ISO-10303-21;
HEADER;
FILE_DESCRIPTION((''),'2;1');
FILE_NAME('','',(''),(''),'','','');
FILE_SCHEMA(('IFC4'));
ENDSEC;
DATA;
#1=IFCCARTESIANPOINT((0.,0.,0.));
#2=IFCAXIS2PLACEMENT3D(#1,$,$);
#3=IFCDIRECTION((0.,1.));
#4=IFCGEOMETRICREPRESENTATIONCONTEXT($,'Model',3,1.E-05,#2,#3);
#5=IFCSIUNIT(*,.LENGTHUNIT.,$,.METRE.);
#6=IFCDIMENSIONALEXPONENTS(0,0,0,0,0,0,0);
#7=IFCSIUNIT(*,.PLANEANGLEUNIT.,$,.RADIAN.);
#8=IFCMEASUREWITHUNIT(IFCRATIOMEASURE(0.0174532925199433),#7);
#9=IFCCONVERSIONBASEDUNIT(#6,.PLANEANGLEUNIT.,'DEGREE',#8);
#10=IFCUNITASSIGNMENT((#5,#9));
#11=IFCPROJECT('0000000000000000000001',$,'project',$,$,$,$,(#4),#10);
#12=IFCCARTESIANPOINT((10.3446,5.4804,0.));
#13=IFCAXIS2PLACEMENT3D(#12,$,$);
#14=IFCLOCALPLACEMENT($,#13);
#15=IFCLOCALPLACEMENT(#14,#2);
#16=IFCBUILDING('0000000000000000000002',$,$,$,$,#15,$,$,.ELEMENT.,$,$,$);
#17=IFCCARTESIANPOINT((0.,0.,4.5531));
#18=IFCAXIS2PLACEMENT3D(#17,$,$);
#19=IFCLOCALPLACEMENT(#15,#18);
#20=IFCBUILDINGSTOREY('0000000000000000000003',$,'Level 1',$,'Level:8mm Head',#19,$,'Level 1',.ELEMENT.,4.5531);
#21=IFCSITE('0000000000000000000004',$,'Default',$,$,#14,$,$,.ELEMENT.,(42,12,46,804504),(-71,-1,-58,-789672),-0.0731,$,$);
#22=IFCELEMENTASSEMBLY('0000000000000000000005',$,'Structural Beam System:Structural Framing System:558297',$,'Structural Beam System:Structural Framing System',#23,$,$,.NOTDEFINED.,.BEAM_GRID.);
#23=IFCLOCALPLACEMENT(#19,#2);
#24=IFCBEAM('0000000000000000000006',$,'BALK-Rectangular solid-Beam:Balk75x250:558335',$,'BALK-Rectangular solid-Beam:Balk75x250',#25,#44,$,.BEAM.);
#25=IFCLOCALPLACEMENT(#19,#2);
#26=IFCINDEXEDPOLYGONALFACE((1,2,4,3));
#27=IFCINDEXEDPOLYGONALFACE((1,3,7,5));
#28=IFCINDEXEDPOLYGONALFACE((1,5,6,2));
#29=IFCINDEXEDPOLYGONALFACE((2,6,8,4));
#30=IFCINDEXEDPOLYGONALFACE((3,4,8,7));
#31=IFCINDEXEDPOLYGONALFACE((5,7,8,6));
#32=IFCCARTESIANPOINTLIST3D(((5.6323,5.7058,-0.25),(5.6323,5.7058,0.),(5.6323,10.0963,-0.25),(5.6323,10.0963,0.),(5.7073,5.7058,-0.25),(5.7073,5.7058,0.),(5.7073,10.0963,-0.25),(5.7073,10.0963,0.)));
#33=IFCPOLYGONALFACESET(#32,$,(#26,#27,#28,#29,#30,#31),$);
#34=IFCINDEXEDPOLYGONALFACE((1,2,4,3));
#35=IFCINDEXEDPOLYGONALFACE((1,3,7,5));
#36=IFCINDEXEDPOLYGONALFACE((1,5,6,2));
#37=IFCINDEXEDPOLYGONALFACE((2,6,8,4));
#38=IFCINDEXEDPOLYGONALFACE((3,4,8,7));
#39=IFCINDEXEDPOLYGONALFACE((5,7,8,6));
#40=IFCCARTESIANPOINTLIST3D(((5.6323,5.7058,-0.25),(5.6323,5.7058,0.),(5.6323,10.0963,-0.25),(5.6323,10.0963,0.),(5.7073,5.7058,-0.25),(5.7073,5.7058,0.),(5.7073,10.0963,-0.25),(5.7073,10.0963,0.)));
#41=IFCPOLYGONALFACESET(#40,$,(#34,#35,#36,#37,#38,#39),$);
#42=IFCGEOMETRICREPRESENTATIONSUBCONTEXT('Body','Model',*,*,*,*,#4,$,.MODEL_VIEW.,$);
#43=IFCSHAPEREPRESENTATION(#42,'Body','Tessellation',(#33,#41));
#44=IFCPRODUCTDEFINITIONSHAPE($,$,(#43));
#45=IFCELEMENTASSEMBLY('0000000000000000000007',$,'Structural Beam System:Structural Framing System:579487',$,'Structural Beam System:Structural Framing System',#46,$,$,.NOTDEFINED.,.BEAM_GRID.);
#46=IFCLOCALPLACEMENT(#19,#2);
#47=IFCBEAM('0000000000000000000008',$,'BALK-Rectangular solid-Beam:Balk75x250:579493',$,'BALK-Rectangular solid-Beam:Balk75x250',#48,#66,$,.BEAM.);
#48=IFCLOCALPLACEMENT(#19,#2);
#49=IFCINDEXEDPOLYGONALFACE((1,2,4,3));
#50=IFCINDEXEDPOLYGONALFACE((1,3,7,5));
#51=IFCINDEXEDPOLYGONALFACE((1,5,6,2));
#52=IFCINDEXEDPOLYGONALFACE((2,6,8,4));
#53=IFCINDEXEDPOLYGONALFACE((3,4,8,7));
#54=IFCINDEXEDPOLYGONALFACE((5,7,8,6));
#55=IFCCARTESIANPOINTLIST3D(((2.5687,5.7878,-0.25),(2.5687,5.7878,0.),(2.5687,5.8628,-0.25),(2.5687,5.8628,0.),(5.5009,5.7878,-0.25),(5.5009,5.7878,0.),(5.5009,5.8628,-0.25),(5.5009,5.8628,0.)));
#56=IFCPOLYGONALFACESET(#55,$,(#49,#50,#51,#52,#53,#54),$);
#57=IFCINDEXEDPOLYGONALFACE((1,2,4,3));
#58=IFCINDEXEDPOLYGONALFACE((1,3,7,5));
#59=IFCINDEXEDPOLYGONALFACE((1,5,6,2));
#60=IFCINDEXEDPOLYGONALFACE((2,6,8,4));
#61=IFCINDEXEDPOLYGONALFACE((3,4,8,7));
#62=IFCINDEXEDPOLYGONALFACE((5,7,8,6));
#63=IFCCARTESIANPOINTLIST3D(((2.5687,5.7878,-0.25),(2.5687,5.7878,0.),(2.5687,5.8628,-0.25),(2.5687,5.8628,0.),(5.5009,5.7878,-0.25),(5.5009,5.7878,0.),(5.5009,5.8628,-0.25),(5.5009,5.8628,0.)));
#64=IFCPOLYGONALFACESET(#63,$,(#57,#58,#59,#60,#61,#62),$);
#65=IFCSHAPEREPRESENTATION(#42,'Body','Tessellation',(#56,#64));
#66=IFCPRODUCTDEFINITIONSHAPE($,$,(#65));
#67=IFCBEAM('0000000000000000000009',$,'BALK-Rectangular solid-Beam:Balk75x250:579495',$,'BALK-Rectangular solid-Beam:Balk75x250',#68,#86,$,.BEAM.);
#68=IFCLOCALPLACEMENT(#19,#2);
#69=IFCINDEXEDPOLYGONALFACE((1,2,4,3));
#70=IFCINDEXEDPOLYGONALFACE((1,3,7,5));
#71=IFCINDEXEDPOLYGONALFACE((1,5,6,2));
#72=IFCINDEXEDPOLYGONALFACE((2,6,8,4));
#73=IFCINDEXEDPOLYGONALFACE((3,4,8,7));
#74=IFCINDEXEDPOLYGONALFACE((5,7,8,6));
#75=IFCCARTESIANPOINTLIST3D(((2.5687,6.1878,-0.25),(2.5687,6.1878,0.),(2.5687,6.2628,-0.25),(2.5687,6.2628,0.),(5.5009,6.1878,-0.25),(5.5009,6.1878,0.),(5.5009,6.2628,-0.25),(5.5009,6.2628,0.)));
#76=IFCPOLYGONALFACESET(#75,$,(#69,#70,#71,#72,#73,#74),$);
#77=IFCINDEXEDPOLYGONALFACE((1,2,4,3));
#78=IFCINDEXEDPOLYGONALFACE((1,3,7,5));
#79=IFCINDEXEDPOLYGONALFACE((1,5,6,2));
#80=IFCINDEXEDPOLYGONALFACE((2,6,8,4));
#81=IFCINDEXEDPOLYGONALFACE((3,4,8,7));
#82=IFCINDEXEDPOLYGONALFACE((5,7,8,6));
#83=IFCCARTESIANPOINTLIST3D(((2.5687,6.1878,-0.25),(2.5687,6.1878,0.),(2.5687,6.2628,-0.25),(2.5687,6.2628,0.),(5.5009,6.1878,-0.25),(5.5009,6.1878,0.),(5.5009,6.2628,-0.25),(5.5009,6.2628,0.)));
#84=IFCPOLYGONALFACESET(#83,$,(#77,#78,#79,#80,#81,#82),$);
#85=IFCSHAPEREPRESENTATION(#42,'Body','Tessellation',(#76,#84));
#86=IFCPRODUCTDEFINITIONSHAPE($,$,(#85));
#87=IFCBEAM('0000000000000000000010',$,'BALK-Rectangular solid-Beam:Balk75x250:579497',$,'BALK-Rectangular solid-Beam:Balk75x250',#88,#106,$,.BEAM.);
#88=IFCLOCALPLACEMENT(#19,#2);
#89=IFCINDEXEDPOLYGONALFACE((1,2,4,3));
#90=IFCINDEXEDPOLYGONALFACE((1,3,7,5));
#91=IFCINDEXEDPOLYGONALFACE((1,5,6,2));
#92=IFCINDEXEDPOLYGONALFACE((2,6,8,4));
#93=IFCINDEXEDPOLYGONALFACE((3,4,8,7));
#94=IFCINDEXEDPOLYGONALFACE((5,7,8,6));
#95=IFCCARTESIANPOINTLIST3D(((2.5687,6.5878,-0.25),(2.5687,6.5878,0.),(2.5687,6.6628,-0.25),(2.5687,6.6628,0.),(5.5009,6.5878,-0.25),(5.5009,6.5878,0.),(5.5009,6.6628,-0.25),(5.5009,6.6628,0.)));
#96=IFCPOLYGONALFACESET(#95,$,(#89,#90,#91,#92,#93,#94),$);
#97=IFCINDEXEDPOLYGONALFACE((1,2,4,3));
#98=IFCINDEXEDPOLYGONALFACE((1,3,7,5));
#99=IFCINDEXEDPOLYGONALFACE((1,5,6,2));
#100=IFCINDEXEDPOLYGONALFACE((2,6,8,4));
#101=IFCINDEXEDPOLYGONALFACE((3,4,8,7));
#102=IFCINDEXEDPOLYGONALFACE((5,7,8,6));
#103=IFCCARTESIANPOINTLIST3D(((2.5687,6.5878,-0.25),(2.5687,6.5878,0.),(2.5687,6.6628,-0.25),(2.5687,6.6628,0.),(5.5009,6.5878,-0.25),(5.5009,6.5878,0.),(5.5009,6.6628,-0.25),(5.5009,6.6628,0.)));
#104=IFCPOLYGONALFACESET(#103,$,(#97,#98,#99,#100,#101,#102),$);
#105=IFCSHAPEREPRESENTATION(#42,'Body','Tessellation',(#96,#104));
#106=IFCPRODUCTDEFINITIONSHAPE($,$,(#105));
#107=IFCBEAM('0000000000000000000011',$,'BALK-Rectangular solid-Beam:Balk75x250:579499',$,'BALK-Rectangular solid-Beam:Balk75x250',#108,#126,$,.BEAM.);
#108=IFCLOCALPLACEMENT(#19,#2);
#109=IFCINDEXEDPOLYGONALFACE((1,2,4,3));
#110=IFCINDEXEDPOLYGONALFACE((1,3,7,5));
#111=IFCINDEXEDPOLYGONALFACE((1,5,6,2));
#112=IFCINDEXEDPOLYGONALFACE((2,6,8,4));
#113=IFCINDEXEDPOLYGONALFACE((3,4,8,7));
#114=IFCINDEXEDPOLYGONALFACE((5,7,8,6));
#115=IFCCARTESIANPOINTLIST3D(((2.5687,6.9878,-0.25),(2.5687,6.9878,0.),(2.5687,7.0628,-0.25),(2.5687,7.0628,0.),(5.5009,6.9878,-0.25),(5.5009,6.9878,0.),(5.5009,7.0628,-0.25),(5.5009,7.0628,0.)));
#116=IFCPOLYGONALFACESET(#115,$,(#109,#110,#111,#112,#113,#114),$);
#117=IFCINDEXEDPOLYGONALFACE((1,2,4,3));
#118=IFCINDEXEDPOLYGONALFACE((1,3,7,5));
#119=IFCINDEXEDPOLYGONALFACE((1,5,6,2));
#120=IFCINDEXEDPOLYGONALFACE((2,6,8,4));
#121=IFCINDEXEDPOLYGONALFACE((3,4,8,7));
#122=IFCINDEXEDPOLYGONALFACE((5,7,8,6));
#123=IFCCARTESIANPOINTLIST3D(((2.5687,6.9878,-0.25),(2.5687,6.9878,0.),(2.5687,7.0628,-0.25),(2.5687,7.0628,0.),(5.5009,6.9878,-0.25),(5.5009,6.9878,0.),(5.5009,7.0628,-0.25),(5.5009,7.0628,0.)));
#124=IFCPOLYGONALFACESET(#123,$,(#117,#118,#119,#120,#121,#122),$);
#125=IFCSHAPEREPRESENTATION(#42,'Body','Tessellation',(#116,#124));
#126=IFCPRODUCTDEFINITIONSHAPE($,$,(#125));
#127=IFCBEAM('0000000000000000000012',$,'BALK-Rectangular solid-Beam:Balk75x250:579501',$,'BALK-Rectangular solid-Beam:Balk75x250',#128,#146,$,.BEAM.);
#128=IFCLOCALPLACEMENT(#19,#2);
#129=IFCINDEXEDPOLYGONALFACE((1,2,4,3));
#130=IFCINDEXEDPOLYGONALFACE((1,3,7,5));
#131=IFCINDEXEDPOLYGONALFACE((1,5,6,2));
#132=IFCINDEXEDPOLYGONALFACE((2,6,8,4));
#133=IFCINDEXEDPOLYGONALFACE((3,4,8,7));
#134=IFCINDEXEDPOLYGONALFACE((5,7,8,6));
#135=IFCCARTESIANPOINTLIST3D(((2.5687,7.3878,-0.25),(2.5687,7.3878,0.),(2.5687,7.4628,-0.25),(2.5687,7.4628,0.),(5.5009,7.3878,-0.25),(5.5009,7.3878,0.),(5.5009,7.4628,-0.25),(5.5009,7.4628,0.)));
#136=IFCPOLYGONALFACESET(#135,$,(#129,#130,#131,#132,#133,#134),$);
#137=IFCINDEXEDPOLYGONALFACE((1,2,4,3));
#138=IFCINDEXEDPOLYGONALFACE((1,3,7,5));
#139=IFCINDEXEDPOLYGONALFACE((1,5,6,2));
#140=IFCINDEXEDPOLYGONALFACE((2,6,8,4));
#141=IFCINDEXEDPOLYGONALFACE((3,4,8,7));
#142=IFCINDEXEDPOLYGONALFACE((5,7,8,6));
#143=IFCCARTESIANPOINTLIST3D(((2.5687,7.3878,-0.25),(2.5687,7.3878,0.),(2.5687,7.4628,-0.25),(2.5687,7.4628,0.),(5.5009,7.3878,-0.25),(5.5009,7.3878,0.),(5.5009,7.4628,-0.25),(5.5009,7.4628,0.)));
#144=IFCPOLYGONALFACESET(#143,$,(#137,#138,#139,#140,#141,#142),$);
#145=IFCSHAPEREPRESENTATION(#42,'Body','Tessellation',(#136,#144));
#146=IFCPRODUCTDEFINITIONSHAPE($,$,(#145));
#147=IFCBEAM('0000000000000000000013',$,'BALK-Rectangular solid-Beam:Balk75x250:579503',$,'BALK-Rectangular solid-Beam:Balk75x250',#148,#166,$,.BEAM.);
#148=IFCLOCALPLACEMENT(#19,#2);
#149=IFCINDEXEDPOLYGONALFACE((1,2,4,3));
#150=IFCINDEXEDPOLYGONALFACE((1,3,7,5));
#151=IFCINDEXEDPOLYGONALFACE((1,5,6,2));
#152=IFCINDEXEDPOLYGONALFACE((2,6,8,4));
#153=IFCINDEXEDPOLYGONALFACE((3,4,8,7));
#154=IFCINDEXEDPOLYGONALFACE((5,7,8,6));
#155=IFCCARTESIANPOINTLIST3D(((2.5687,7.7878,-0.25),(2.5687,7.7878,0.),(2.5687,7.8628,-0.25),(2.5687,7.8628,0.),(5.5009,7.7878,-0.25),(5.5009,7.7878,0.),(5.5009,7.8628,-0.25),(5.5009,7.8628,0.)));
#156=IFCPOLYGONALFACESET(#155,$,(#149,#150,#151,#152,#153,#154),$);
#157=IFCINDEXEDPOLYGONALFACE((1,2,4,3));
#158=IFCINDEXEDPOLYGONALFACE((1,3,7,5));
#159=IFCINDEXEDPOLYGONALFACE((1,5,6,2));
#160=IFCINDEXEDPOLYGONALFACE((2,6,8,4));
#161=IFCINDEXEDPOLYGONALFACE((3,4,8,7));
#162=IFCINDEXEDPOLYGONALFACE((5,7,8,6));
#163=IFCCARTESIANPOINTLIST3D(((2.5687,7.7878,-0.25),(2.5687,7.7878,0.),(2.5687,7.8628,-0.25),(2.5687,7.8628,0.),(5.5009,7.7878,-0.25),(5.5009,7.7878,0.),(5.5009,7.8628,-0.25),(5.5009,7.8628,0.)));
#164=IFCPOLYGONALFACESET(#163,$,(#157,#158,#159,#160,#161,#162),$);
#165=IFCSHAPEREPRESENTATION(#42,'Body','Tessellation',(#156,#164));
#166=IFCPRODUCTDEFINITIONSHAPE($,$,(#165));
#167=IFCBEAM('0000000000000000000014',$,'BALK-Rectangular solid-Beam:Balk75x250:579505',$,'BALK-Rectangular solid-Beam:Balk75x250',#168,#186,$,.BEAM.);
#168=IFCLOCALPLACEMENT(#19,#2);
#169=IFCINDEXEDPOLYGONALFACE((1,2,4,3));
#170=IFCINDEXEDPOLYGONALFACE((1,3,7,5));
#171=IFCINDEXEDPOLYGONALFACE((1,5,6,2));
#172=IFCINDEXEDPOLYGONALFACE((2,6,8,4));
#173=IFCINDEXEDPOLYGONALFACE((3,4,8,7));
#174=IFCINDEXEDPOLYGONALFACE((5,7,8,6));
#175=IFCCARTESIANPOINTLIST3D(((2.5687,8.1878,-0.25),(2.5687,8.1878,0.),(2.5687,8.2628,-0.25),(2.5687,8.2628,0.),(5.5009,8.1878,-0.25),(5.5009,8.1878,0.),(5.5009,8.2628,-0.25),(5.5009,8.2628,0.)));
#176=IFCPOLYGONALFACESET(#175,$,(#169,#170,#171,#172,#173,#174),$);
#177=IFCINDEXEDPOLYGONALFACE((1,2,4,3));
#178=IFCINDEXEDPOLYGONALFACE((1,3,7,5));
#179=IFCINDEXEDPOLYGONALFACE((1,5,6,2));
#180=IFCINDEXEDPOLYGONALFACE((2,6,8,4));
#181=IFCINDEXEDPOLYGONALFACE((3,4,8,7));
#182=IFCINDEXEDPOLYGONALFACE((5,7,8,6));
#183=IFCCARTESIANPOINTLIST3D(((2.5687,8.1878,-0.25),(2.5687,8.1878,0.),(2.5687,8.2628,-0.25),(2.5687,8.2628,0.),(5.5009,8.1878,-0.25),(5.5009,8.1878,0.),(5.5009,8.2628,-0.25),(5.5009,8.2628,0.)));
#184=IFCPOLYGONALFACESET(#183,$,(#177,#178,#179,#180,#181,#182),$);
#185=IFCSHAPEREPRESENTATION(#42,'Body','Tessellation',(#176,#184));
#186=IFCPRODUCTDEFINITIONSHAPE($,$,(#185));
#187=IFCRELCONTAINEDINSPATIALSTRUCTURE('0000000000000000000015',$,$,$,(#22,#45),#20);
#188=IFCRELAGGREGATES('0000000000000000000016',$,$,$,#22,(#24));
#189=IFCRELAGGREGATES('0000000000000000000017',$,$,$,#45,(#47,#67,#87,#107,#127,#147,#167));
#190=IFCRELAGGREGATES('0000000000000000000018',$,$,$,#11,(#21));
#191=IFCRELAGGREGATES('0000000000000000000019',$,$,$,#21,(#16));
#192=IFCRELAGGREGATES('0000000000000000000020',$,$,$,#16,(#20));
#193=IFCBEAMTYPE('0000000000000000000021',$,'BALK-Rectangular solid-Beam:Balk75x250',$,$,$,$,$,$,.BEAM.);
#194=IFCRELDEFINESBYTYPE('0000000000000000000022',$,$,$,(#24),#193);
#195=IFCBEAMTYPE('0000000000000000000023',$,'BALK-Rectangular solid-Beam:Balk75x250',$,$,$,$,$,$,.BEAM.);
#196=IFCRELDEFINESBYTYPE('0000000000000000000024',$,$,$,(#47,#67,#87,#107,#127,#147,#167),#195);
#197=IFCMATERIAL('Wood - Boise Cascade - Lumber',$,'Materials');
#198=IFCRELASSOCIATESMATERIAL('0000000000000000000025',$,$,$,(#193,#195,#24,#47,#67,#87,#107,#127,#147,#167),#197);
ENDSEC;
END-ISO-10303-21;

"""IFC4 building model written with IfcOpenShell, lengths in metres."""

from ifc_helpers import new_model, entity, si_unit, converted_unit, direction, frame, frame_2d, origin, origin_2d_with_axis, place, context, subcontext, project, spatial, rectangle, extrude, source, transform, mapped, material, material_profile, profile_set, profile_usage, type_object, type_shapes, element, aggregate, save


model = new_model("IFC4")

# Units and contexts
model_context = context("Model", 3, precision=1e-05, world=origin(), true_north=direction((0.0, 1.0)))
body_context = subcontext(model_context, "Body", "Model", "MODEL_VIEW")
ifc_project = project(units=[si_unit("LENGTHUNIT", "METRE"), converted_unit("PLANEANGLEUNIT", "DEGREE", entity("IfcRatioMeasure", 0.0174532925199433), si_unit("PLANEANGLEUNIT", "RADIAN"), dimensions=[0, 0, 0, 0, 0, 0, 0])], contexts=[model_context])

# Site, building, storey
site_placement = place(None, frame((10.3446, 5.4804, 0.0)))
site = spatial("IfcSite", under=ifc_project, at=site_placement, Name="Default", CompositionType="ELEMENT", RefLatitude=(42, 12, 46, 804504), RefLongitude=(-71, -1, -58, -789672), RefElevation=-0.0731)
building_placement = place(site_placement, origin())
building = spatial("IfcBuilding", under=site, at=building_placement, CompositionType="ELEMENT")
storey_placement = place(building_placement, frame((0.0, 0.0, 4.5531)))
storey = spatial("IfcBuildingStorey", under=building, at=storey_placement, Name="Level 1", ObjectType="Level:8mm Head", LongName="Level 1", CompositionType="ELEMENT", Elevation=4.5531)

# Element assembly, beam
assembly_1_placement = place(storey_placement, origin())
assembly_1 = element("IfcElementAssembly", 1, at=assembly_1_placement, inside=storey, Name="Structural Beam System:Structural Framing System:558297", ObjectType="Structural Beam System:Structural Framing System", AssemblyPlace="NOTDEFINED", PredefinedType="BEAM_GRID")
ifc_material_1 = material(Name="Wood - Boise Cascade - Lumber", Category="Materials")
ifc_material_profile = material_profile(ifc_material_1, rectangle(XDim=0.25, YDim=0.075, at=frame_2d((0.0, 0.0), x_axis=(1.0, 0.0))), Name="Balk75x250")
ifc_profile_set = profile_set([ifc_material_profile], Name="Balk75x250")
ifc_profile_usage_1 = profile_usage(ifc_profile_set, cardinal=8)
beam_type_1 = type_object("IfcBeamType", Name="BALK-Rectangular solid-Beam:Balk75x250", PredefinedType="BEAM", material=ifc_profile_set)
shared_shape_1 = source(origin(), body_context, "Body", "SweptSolid", [
    extrude(rectangle(XDim=0.25, YDim=0.075, at=origin_2d_with_axis()), frame((-2.089, 0.0, 0.0), z_axis=(1.0, 0.0, 0.0), x_axis=(0.0, 0.0, -1.0)), (0.0, 0.0, 1.0), 4.3905),
    extrude(rectangle(XDim=0.25, YDim=0.075, at=origin_2d_with_axis()), frame((-2.089, 0.0, 0.0), z_axis=(1.0, 0.0, 0.0), x_axis=(0.0, 0.0, -1.0)), (0.0, 0.0, 1.0), 4.3905),
])
type_shapes(beam_type_1, [shared_shape_1])
beam_1_placement = place(assembly_1_placement, frame((5.6698, 8.0073, -0.125), z_axis=(0.0, 0.0, 1.0), x_axis=(0.0, -1.0, 0.0)))
beam_1 = element("IfcBeam", 2, at=beam_1_placement, type_object=beam_type_1, material=ifc_profile_usage_1, Name="BALK-Rectangular solid-Beam:Balk75x250:558335", ObjectType="BALK-Rectangular solid-Beam:Balk75x250", PredefinedType="BEAM", context=body_context, shape_type="MappedRepresentation", body=[
    mapped(shared_shape_1, transform((0.0, 0.0, 0.0), scale=1.0)),
])
aggregate(assembly_1, [beam_1])

# Element assembly, beams
assembly_2_placement = place(storey_placement, origin())
assembly_2 = element("IfcElementAssembly", 3, at=assembly_2_placement, inside=storey, Name="Structural Beam System:Structural Framing System:579487", ObjectType="Structural Beam System:Structural Framing System", AssemblyPlace="NOTDEFINED", PredefinedType="BEAM_GRID")
ifc_profile_usage_2 = profile_usage(ifc_profile_set, cardinal=8)
beam_type_2 = type_object("IfcBeamType", Name="BALK-Rectangular solid-Beam:Balk75x250", PredefinedType="BEAM", material=ifc_profile_set)
shared_shape_2 = source(origin(), body_context, "Body", "SweptSolid", [
    extrude(rectangle(XDim=0.25, YDim=0.075, at=origin_2d_with_axis()), frame((-1.5724, 0.0, 0.0), z_axis=(1.0, 0.0, 0.0), x_axis=(0.0, 0.0, -1.0)), (0.0, 0.0, 1.0), 2.9322),
    extrude(rectangle(XDim=0.25, YDim=0.075, at=origin_2d_with_axis()), frame((-1.5724, 0.0, 0.0), z_axis=(1.0, 0.0, 0.0), x_axis=(0.0, 0.0, -1.0)), (0.0, 0.0, 1.0), 2.9322),
])
type_shapes(beam_type_2, [shared_shape_2])
beam_2_placement = place(assembly_2_placement, frame((3.9285, 5.8253, -0.125), z_axis=(0.0, 0.0, 1.0), x_axis=(-1.0, 0.0, 0.0)))
beam_2 = element("IfcBeam", 4, at=beam_2_placement, type_object=beam_type_2, material=ifc_profile_usage_2, Name="BALK-Rectangular solid-Beam:Balk75x250:579493", ObjectType="BALK-Rectangular solid-Beam:Balk75x250", PredefinedType="BEAM", context=body_context, shape_type="MappedRepresentation", body=[
    mapped(shared_shape_2, transform((0.0, 0.0, 0.0), scale=1.0)),
])
ifc_profile_usage_3 = profile_usage(ifc_profile_set, cardinal=8)
beam_3_placement = place(assembly_2_placement, frame((3.9285, 6.2253, -0.125), z_axis=(0.0, 0.0, 1.0), x_axis=(-1.0, 0.0, 0.0)))
beam_3 = element("IfcBeam", 5, at=beam_3_placement, type_object=beam_type_2, material=ifc_profile_usage_3, Name="BALK-Rectangular solid-Beam:Balk75x250:579495", ObjectType="BALK-Rectangular solid-Beam:Balk75x250", PredefinedType="BEAM", context=body_context, shape_type="MappedRepresentation", body=[
    mapped(shared_shape_2, transform((0.0, 0.0, 0.0), scale=1.0)),
])
ifc_profile_usage_4 = profile_usage(ifc_profile_set, cardinal=8)
beam_4_placement = place(assembly_2_placement, frame((3.9285, 6.6253, -0.125), z_axis=(0.0, 0.0, 1.0), x_axis=(-1.0, 0.0, 0.0)))
beam_4 = element("IfcBeam", 6, at=beam_4_placement, type_object=beam_type_2, material=ifc_profile_usage_4, Name="BALK-Rectangular solid-Beam:Balk75x250:579497", ObjectType="BALK-Rectangular solid-Beam:Balk75x250", PredefinedType="BEAM", context=body_context, shape_type="MappedRepresentation", body=[
    mapped(shared_shape_2, transform((0.0, 0.0, 0.0), scale=1.0)),
])
ifc_profile_usage_5 = profile_usage(ifc_profile_set, cardinal=8)
beam_5_placement = place(assembly_2_placement, frame((3.9285, 7.0253, -0.125), z_axis=(0.0, 0.0, 1.0), x_axis=(-1.0, 0.0, 0.0)))
beam_5 = element("IfcBeam", 7, at=beam_5_placement, type_object=beam_type_2, material=ifc_profile_usage_5, Name="BALK-Rectangular solid-Beam:Balk75x250:579499", ObjectType="BALK-Rectangular solid-Beam:Balk75x250", PredefinedType="BEAM", context=body_context, shape_type="MappedRepresentation", body=[
    mapped(shared_shape_2, transform((0.0, 0.0, 0.0), scale=1.0)),
])
ifc_profile_usage_6 = profile_usage(ifc_profile_set, cardinal=8)
beam_6_placement = place(assembly_2_placement, frame((3.9285, 7.4253, -0.125), z_axis=(0.0, 0.0, 1.0), x_axis=(-1.0, 0.0, 0.0)))
beam_6 = element("IfcBeam", 8, at=beam_6_placement, type_object=beam_type_2, material=ifc_profile_usage_6, Name="BALK-Rectangular solid-Beam:Balk75x250:579501", ObjectType="BALK-Rectangular solid-Beam:Balk75x250", PredefinedType="BEAM", context=body_context, shape_type="MappedRepresentation", body=[
    mapped(shared_shape_2, transform((0.0, 0.0, 0.0), scale=1.0)),
])
ifc_profile_usage_7 = profile_usage(ifc_profile_set, cardinal=8)
beam_7_placement = place(assembly_2_placement, frame((3.9285, 7.8253, -0.125), z_axis=(0.0, 0.0, 1.0), x_axis=(-1.0, 0.0, 0.0)))
beam_7 = element("IfcBeam", 9, at=beam_7_placement, type_object=beam_type_2, material=ifc_profile_usage_7, Name="BALK-Rectangular solid-Beam:Balk75x250:579503", ObjectType="BALK-Rectangular solid-Beam:Balk75x250", PredefinedType="BEAM", context=body_context, shape_type="MappedRepresentation", body=[
    mapped(shared_shape_2, transform((0.0, 0.0, 0.0), scale=1.0)),
])
ifc_profile_usage_8 = profile_usage(ifc_profile_set, cardinal=8)
beam_8_placement = place(assembly_2_placement, frame((3.9285, 8.2253, -0.125), z_axis=(0.0, 0.0, 1.0), x_axis=(-1.0, 0.0, 0.0)))
beam_8 = element("IfcBeam", 10, at=beam_8_placement, type_object=beam_type_2, material=ifc_profile_usage_8, Name="BALK-Rectangular solid-Beam:Balk75x250:579505", ObjectType="BALK-Rectangular solid-Beam:Balk75x250", PredefinedType="BEAM", context=body_context, shape_type="MappedRepresentation", body=[
    mapped(shared_shape_2, transform((0.0, 0.0, 0.0), scale=1.0)),
])
aggregate(assembly_2, [beam_2, beam_3, beam_4, beam_5, beam_6, beam_7, beam_8])

save(model, "model.ifc")
